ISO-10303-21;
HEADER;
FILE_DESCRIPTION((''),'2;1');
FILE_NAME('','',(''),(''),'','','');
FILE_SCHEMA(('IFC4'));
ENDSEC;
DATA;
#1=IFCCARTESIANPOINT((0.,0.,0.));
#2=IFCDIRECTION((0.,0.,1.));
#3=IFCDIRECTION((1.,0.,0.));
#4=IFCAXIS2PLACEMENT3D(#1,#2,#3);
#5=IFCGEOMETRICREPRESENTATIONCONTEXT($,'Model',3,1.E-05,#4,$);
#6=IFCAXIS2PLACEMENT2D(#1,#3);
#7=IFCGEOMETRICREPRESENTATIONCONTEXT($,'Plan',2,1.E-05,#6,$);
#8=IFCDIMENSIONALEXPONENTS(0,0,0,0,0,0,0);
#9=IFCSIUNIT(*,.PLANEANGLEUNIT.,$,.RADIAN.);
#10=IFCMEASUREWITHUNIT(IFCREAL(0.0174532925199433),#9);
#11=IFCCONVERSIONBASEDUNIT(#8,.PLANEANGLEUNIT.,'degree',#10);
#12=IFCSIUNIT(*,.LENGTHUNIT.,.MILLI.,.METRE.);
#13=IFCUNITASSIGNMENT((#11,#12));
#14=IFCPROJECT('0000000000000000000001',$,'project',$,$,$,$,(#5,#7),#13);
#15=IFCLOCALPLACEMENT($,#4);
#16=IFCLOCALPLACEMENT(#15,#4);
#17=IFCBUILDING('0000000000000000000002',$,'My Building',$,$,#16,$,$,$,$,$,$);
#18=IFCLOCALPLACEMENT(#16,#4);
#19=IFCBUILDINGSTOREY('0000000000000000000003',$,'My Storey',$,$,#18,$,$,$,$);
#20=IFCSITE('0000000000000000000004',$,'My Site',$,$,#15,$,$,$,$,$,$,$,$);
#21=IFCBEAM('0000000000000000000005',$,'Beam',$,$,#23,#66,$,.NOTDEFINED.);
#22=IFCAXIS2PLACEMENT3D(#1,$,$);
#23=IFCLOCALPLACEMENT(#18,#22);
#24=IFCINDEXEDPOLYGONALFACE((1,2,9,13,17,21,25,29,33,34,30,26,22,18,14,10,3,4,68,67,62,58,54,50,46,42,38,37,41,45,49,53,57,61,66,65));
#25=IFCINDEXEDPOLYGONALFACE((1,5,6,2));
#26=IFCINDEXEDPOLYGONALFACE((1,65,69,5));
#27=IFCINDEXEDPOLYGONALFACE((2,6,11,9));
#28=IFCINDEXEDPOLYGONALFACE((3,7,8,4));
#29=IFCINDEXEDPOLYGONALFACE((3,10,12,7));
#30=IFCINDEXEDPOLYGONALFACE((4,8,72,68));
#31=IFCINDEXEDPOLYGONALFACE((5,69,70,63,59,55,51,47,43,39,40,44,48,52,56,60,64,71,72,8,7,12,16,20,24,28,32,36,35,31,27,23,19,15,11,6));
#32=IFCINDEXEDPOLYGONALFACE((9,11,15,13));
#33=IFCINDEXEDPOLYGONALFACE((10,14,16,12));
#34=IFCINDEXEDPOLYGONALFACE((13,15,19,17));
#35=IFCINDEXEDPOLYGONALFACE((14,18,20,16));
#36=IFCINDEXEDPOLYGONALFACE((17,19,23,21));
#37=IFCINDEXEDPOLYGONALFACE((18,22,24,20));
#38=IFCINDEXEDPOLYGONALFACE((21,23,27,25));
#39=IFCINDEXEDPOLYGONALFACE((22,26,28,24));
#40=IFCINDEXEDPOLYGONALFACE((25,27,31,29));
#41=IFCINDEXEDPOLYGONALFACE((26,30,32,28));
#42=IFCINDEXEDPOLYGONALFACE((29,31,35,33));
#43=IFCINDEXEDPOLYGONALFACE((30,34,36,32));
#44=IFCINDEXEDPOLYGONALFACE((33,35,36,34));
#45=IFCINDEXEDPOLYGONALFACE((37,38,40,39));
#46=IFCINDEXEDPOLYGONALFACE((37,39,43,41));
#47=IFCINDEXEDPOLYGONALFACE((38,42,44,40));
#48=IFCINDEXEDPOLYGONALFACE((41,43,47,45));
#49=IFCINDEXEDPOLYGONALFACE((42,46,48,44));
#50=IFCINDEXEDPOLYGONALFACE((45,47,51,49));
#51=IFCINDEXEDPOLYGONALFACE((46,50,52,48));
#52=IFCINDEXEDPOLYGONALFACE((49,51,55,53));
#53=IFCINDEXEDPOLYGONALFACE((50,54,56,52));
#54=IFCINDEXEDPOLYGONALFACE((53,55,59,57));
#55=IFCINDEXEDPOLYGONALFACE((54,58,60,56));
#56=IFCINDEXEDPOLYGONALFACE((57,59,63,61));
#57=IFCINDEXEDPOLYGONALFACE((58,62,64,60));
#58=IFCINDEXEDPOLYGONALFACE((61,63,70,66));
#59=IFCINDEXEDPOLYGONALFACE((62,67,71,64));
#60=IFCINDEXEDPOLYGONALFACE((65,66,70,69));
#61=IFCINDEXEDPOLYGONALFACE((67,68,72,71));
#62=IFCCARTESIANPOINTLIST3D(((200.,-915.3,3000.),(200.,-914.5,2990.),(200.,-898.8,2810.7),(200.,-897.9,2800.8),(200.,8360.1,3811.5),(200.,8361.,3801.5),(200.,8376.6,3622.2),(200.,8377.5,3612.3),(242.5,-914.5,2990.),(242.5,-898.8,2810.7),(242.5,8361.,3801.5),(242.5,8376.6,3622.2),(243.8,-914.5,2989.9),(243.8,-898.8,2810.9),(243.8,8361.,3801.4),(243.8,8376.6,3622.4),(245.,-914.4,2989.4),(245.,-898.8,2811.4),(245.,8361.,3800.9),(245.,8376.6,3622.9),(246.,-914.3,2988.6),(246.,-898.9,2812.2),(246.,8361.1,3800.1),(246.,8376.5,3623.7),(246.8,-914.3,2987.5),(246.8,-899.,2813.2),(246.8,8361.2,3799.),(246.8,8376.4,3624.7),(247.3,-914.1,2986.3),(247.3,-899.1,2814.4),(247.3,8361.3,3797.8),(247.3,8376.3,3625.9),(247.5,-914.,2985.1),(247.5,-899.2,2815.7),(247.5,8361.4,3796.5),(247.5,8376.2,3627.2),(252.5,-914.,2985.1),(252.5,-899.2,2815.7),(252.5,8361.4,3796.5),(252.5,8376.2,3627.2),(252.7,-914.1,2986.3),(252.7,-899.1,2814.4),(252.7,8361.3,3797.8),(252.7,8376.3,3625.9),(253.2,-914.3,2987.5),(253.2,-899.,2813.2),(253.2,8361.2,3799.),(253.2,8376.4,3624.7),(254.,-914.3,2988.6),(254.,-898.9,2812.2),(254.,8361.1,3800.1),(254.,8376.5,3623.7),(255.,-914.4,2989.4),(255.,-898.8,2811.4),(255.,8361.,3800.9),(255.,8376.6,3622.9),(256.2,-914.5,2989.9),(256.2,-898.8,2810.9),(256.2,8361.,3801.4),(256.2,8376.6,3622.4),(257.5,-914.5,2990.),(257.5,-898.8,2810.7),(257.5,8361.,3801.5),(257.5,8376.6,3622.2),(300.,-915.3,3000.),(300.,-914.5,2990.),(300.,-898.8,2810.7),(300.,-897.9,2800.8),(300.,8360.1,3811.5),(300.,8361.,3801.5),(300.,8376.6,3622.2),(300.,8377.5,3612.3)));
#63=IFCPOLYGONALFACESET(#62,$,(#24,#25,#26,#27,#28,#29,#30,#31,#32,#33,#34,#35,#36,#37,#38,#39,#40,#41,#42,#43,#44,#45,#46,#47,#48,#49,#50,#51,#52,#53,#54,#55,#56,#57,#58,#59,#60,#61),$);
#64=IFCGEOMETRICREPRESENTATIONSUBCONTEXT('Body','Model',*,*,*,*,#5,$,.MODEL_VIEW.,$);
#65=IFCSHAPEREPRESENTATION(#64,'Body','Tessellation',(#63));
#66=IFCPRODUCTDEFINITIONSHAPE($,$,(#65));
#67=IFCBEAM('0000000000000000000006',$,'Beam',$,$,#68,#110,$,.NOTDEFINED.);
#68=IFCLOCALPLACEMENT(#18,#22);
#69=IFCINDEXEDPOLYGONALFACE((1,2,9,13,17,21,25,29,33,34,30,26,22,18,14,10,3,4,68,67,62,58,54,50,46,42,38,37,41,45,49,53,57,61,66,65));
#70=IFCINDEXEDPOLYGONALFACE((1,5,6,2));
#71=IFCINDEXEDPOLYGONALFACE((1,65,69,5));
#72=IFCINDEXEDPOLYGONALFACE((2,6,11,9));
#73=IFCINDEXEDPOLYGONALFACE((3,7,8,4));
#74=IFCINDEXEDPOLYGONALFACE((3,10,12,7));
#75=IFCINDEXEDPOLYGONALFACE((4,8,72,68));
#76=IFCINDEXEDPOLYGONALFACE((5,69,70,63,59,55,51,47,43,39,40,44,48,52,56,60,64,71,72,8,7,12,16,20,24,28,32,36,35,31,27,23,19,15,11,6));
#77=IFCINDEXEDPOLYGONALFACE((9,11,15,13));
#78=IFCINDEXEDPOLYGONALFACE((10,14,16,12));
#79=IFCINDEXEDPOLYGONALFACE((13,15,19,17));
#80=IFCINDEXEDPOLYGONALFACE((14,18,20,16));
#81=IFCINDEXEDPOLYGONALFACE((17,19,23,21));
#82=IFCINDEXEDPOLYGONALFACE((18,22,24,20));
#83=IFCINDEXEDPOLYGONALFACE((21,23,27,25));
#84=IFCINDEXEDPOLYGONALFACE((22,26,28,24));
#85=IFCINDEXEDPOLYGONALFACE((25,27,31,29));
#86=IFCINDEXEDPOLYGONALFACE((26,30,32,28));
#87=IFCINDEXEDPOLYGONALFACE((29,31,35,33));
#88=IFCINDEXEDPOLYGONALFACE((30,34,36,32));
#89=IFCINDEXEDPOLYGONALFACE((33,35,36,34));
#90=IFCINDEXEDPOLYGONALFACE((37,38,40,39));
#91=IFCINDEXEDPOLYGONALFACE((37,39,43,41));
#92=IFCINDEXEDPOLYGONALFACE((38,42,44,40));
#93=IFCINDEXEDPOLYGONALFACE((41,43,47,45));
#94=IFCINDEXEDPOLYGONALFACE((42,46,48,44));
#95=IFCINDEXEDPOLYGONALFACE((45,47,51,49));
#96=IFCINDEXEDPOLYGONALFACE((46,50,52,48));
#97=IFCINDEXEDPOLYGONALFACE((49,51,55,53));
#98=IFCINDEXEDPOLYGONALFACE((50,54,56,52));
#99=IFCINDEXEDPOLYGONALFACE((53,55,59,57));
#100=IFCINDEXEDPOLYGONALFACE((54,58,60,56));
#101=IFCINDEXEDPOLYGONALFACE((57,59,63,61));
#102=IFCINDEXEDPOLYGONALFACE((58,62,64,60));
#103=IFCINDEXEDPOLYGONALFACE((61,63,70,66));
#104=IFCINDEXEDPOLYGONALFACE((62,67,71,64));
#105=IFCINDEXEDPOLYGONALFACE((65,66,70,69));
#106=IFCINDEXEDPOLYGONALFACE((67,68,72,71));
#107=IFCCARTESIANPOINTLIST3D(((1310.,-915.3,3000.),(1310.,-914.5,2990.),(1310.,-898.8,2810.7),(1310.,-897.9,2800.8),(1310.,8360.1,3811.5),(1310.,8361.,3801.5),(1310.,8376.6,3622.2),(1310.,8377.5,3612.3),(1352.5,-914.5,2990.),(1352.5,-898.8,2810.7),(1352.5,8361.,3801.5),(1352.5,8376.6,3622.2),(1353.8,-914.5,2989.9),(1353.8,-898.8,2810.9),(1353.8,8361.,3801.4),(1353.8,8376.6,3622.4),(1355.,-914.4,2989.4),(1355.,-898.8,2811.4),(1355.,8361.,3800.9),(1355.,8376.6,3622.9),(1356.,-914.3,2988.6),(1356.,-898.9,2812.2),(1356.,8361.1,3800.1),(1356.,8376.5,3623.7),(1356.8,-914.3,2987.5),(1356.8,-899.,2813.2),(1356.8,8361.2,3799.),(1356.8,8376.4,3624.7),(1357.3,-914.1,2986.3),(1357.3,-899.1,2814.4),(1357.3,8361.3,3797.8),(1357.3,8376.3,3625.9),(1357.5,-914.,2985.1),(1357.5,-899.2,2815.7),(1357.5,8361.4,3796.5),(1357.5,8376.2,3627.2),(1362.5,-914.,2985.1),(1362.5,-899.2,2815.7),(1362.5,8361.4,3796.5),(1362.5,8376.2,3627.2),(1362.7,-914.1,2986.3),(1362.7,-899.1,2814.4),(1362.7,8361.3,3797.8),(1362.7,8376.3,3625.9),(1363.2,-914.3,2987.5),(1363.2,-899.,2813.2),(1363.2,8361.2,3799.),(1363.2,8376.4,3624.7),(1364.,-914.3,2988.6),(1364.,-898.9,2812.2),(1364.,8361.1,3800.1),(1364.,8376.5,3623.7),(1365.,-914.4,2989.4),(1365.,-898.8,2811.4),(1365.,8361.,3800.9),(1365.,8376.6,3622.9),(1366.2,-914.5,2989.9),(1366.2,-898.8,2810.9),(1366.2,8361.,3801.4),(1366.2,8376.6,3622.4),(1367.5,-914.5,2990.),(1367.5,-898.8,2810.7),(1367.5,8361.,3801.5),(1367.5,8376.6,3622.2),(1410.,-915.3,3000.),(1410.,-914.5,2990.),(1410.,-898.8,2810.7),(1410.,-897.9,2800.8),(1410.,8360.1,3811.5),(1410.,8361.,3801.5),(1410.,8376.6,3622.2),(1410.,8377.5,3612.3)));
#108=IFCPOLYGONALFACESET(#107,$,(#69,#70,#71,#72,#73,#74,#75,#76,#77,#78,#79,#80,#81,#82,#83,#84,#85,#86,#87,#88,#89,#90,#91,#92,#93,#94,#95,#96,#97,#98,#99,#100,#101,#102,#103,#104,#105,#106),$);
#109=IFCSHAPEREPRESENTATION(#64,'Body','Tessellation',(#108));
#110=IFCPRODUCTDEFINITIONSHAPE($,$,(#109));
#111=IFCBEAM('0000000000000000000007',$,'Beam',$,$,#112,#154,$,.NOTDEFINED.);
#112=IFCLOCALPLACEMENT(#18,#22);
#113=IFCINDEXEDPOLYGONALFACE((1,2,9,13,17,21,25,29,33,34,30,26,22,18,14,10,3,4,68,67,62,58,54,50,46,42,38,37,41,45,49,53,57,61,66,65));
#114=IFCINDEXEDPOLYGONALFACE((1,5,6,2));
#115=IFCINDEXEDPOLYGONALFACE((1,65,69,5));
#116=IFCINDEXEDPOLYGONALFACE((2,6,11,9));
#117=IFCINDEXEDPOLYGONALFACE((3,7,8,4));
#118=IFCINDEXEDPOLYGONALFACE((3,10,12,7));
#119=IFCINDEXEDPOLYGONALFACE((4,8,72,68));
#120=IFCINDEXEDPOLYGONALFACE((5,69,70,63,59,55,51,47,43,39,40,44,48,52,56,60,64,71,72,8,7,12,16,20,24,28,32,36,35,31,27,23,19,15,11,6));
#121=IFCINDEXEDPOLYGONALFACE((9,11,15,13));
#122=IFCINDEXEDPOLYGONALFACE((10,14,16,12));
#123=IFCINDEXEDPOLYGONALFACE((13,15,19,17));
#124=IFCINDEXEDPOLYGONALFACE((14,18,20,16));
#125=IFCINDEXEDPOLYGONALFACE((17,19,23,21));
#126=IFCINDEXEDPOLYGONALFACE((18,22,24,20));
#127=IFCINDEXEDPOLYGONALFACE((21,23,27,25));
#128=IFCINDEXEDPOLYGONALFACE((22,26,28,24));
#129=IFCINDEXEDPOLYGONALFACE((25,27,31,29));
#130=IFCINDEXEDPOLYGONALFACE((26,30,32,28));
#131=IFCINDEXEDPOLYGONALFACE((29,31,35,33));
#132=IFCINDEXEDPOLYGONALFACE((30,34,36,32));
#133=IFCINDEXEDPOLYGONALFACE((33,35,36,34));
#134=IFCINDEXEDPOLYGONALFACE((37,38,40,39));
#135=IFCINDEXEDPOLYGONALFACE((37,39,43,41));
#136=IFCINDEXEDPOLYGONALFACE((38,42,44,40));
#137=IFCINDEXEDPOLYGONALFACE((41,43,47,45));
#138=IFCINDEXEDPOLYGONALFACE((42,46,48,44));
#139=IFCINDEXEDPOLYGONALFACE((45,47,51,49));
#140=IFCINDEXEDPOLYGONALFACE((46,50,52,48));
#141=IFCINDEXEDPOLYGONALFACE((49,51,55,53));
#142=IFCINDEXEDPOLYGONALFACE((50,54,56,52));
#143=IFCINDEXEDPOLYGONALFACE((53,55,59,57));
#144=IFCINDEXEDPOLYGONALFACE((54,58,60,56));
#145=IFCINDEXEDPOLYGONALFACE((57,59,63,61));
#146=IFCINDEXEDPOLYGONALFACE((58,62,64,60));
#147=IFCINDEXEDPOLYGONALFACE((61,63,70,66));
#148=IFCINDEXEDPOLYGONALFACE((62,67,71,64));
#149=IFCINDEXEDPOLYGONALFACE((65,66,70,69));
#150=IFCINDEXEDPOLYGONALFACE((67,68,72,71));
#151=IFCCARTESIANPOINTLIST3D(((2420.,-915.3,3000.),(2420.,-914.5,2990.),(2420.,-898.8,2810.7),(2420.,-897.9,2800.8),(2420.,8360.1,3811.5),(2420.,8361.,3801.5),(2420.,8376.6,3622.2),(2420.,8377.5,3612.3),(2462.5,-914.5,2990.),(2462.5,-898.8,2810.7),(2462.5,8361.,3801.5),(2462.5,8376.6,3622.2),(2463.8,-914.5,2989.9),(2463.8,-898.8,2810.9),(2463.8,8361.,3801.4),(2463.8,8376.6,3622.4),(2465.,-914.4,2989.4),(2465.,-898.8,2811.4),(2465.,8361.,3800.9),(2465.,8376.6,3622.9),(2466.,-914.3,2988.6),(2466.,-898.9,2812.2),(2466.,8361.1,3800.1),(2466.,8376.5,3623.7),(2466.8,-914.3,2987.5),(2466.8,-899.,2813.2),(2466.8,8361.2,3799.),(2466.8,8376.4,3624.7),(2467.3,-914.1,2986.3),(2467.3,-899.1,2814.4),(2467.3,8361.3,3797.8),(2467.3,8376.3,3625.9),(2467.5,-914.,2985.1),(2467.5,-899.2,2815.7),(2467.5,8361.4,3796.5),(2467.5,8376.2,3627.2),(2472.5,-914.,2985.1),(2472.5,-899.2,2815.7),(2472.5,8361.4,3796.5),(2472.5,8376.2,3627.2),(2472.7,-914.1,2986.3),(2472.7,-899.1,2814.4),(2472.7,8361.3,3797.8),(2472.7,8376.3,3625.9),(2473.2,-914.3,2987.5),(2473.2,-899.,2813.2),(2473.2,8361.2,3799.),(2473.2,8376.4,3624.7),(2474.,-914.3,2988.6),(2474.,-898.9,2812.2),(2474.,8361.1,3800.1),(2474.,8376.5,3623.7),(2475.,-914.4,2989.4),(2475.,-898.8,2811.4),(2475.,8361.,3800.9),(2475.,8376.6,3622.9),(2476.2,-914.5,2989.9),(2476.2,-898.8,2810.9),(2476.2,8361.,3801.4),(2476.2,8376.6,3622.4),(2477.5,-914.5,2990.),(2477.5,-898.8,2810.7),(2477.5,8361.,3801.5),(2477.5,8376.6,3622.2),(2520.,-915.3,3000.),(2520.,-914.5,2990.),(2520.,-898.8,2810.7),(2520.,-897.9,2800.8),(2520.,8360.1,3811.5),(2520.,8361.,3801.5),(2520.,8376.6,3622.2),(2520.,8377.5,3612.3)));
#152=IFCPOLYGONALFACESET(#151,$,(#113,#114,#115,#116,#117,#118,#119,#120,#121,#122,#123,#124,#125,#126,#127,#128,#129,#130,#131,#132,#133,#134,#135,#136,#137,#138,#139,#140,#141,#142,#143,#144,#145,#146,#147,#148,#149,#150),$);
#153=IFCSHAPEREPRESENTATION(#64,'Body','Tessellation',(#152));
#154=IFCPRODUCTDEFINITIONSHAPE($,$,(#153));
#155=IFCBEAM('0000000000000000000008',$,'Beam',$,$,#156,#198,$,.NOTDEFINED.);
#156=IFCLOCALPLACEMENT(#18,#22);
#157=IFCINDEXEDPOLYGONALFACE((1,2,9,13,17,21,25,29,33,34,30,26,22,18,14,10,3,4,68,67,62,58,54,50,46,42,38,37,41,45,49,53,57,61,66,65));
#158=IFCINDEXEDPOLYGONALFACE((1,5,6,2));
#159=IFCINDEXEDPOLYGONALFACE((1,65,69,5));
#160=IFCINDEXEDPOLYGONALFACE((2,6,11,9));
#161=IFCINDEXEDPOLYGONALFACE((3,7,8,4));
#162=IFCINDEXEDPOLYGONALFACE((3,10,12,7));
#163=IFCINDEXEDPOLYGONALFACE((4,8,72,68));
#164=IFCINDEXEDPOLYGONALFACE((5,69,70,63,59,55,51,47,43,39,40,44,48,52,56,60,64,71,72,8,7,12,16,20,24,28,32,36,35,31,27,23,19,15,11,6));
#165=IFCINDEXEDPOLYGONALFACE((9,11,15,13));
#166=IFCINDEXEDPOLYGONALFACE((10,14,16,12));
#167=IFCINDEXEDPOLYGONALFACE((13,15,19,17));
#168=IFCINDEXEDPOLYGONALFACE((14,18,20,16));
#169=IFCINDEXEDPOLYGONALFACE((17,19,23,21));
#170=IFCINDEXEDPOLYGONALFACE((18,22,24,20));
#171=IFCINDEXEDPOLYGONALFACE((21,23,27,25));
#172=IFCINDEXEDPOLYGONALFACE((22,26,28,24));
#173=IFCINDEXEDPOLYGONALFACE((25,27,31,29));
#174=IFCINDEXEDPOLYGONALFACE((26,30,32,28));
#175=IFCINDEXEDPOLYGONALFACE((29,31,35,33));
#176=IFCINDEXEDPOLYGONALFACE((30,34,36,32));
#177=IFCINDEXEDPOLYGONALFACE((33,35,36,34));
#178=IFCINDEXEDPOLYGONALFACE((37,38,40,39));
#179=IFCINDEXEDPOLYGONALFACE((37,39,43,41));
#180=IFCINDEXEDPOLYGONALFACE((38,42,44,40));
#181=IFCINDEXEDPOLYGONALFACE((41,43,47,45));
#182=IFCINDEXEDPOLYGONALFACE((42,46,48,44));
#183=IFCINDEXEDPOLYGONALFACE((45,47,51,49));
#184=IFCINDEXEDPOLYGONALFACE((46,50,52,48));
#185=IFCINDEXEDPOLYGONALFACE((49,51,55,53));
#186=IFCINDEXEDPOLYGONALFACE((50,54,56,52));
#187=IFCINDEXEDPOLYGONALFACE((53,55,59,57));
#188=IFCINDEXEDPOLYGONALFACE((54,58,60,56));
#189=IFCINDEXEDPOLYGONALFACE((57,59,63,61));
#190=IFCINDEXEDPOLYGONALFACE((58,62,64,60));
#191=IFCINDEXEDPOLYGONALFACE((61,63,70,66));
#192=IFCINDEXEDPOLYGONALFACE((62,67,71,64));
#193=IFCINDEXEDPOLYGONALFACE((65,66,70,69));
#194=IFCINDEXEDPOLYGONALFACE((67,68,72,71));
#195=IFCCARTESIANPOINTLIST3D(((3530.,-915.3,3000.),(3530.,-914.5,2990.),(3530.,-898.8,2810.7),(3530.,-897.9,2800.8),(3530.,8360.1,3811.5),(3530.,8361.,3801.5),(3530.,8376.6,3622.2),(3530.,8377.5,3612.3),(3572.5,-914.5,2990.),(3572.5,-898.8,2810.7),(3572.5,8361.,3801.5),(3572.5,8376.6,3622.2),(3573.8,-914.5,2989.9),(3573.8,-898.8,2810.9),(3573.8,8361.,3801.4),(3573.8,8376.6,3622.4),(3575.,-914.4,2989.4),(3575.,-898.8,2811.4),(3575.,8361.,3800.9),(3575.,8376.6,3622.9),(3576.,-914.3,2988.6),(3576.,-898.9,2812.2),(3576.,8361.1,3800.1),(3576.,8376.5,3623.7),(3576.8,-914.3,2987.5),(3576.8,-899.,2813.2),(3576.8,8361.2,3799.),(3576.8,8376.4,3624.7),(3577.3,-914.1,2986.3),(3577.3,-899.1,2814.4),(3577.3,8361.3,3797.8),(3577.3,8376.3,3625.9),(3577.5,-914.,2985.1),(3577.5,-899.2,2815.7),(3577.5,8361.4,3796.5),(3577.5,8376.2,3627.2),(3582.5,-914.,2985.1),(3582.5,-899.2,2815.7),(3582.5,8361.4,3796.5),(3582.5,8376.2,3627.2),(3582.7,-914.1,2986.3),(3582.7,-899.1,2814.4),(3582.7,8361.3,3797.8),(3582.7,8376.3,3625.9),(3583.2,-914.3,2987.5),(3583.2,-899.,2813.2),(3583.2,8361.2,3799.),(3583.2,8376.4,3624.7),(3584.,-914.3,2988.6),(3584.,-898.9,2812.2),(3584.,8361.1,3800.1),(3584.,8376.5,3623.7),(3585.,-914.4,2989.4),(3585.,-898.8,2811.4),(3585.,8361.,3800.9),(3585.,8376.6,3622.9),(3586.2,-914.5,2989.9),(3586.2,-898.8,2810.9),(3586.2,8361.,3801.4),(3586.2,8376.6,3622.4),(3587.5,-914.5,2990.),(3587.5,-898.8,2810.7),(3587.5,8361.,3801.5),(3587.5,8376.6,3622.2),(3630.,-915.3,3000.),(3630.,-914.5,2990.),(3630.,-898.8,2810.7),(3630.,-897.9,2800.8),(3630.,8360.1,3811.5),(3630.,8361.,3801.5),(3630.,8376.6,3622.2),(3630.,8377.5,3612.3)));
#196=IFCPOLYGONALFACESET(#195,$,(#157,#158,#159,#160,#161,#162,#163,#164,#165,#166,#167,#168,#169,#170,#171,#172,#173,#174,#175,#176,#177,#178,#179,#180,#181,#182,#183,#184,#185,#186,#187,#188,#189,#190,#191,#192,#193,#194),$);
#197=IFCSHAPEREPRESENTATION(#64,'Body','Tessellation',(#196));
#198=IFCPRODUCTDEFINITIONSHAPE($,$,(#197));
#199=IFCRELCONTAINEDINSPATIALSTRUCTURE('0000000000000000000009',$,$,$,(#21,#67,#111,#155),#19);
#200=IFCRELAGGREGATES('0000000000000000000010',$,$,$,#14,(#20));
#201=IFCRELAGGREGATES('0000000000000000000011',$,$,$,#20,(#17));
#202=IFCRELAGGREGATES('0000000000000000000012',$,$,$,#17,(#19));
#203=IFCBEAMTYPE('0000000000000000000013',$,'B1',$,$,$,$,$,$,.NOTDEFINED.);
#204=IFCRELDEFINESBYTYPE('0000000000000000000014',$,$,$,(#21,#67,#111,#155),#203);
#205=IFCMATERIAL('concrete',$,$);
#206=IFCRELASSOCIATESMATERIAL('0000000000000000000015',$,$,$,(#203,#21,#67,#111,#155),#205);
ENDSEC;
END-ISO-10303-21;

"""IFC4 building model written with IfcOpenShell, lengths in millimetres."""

from ifc_helpers import new_model, entity, si_unit, converted_unit, frame, frame_2d, origin_with_axes, place, context, subcontext, project, spatial, i_section, extrude, material, material_profile, profile_set, profile_usage, type_object, element, save


model = new_model("IFC4")

# Units and contexts
model_context = context("Model", 3, precision=1e-05, world=origin_with_axes())
plan_context = context("Plan", 2, precision=1e-05, world=frame_2d((0.0, 0.0, 0.0), x_axis=(1.0, 0.0, 0.0)))
body_context = subcontext(model_context, "Body", "Model", "MODEL_VIEW")
ifc_project = project(units=[converted_unit("PLANEANGLEUNIT", "degree", entity("IfcReal", 0.0174532925199433), si_unit("PLANEANGLEUNIT", "RADIAN"), dimensions=[0, 0, 0, 0, 0, 0, 0]), si_unit("LENGTHUNIT", "METRE", prefix="MILLI")], contexts=[model_context, plan_context])

# Site, building, storey
site_placement = place(None, origin_with_axes())
site = spatial("IfcSite", under=ifc_project, at=site_placement, Name="My Site")
building_placement = place(site_placement, origin_with_axes())
building = spatial("IfcBuilding", under=site, at=building_placement, Name="My Building")
storey_placement = place(building_placement, origin_with_axes())
storey = spatial("IfcBuildingStorey", under=building, at=storey_placement, Name="My Storey")

# Beams
ifc_material = material(Name="concrete")
ifc_material_profile = material_profile(ifc_material, i_section(OverallWidth=100.0, OverallDepth=200.0, WebThickness=5.0, FlangeThickness=10.0, FilletRadius=5.0))
ifc_profile_set = profile_set([ifc_material_profile])
ifc_profile_usage_1 = profile_usage(ifc_profile_set, cardinal=5)
beam_type = type_object("IfcBeamType", Name="B1", PredefinedType="NOTDEFINED", material=ifc_profile_set)
beam_1_placement = place(storey_placement, frame((250.0, -906.6, 2900.4), z_axis=(-0.000001, 0.996195, 0.087156), x_axis=(-1.0, -0.000001, 0.0)))
element("IfcBeam", 1, at=beam_1_placement, inside=storey, type_object=beam_type, material=ifc_profile_usage_1, Name="Beam", PredefinedType="NOTDEFINED", context=body_context, shape_type="SweptSolid", body=[
    extrude(i_section(OverallWidth=100.0, OverallDepth=200.0, WebThickness=5.0, FlangeThickness=10.0, FilletRadius=5.0), origin_with_axes(), (0.0, 0.0, 1.0), 9310.9),
])
ifc_profile_usage_2 = profile_usage(ifc_profile_set, cardinal=5)
beam_2_placement = place(storey_placement, frame((1360.0, -906.6, 2900.4), z_axis=(-0.000001, 0.996195, 0.087156), x_axis=(-1.0, -0.000001, 0.0)))
element("IfcBeam", 2, at=beam_2_placement, inside=storey, type_object=beam_type, material=ifc_profile_usage_2, Name="Beam", PredefinedType="NOTDEFINED", context=body_context, shape_type="SweptSolid", body=[
    extrude(i_section(OverallWidth=100.0, OverallDepth=200.0, WebThickness=5.0, FlangeThickness=10.0, FilletRadius=5.0), origin_with_axes(), (0.0, 0.0, 1.0), 9310.9),
])
ifc_profile_usage_3 = profile_usage(ifc_profile_set, cardinal=5)
beam_3_placement = place(storey_placement, frame((2470.0, -906.6, 2900.4), z_axis=(-0.000001, 0.996195, 0.087156), x_axis=(-1.0, -0.000001, 0.0)))
element("IfcBeam", 3, at=beam_3_placement, inside=storey, type_object=beam_type, material=ifc_profile_usage_3, Name="Beam", PredefinedType="NOTDEFINED", context=body_context, shape_type="SweptSolid", body=[
    extrude(i_section(OverallWidth=100.0, OverallDepth=200.0, WebThickness=5.0, FlangeThickness=10.0, FilletRadius=5.0), origin_with_axes(), (0.0, 0.0, 1.0), 9310.9),
])
ifc_profile_usage_4 = profile_usage(ifc_profile_set, cardinal=5)
beam_4_placement = place(storey_placement, frame((3580.0, -906.6, 2900.4), z_axis=(-0.000001, 0.996195, 0.087156), x_axis=(-1.0, -0.000001, 0.0)))
element("IfcBeam", 4, at=beam_4_placement, inside=storey, type_object=beam_type, material=ifc_profile_usage_4, Name="Beam", PredefinedType="NOTDEFINED", context=body_context, shape_type="SweptSolid", body=[
    extrude(i_section(OverallWidth=100.0, OverallDepth=200.0, WebThickness=5.0, FlangeThickness=10.0, FilletRadius=5.0), origin_with_axes(), (0.0, 0.0, 1.0), 9310.9),
])

save(model, "model.ifc")
